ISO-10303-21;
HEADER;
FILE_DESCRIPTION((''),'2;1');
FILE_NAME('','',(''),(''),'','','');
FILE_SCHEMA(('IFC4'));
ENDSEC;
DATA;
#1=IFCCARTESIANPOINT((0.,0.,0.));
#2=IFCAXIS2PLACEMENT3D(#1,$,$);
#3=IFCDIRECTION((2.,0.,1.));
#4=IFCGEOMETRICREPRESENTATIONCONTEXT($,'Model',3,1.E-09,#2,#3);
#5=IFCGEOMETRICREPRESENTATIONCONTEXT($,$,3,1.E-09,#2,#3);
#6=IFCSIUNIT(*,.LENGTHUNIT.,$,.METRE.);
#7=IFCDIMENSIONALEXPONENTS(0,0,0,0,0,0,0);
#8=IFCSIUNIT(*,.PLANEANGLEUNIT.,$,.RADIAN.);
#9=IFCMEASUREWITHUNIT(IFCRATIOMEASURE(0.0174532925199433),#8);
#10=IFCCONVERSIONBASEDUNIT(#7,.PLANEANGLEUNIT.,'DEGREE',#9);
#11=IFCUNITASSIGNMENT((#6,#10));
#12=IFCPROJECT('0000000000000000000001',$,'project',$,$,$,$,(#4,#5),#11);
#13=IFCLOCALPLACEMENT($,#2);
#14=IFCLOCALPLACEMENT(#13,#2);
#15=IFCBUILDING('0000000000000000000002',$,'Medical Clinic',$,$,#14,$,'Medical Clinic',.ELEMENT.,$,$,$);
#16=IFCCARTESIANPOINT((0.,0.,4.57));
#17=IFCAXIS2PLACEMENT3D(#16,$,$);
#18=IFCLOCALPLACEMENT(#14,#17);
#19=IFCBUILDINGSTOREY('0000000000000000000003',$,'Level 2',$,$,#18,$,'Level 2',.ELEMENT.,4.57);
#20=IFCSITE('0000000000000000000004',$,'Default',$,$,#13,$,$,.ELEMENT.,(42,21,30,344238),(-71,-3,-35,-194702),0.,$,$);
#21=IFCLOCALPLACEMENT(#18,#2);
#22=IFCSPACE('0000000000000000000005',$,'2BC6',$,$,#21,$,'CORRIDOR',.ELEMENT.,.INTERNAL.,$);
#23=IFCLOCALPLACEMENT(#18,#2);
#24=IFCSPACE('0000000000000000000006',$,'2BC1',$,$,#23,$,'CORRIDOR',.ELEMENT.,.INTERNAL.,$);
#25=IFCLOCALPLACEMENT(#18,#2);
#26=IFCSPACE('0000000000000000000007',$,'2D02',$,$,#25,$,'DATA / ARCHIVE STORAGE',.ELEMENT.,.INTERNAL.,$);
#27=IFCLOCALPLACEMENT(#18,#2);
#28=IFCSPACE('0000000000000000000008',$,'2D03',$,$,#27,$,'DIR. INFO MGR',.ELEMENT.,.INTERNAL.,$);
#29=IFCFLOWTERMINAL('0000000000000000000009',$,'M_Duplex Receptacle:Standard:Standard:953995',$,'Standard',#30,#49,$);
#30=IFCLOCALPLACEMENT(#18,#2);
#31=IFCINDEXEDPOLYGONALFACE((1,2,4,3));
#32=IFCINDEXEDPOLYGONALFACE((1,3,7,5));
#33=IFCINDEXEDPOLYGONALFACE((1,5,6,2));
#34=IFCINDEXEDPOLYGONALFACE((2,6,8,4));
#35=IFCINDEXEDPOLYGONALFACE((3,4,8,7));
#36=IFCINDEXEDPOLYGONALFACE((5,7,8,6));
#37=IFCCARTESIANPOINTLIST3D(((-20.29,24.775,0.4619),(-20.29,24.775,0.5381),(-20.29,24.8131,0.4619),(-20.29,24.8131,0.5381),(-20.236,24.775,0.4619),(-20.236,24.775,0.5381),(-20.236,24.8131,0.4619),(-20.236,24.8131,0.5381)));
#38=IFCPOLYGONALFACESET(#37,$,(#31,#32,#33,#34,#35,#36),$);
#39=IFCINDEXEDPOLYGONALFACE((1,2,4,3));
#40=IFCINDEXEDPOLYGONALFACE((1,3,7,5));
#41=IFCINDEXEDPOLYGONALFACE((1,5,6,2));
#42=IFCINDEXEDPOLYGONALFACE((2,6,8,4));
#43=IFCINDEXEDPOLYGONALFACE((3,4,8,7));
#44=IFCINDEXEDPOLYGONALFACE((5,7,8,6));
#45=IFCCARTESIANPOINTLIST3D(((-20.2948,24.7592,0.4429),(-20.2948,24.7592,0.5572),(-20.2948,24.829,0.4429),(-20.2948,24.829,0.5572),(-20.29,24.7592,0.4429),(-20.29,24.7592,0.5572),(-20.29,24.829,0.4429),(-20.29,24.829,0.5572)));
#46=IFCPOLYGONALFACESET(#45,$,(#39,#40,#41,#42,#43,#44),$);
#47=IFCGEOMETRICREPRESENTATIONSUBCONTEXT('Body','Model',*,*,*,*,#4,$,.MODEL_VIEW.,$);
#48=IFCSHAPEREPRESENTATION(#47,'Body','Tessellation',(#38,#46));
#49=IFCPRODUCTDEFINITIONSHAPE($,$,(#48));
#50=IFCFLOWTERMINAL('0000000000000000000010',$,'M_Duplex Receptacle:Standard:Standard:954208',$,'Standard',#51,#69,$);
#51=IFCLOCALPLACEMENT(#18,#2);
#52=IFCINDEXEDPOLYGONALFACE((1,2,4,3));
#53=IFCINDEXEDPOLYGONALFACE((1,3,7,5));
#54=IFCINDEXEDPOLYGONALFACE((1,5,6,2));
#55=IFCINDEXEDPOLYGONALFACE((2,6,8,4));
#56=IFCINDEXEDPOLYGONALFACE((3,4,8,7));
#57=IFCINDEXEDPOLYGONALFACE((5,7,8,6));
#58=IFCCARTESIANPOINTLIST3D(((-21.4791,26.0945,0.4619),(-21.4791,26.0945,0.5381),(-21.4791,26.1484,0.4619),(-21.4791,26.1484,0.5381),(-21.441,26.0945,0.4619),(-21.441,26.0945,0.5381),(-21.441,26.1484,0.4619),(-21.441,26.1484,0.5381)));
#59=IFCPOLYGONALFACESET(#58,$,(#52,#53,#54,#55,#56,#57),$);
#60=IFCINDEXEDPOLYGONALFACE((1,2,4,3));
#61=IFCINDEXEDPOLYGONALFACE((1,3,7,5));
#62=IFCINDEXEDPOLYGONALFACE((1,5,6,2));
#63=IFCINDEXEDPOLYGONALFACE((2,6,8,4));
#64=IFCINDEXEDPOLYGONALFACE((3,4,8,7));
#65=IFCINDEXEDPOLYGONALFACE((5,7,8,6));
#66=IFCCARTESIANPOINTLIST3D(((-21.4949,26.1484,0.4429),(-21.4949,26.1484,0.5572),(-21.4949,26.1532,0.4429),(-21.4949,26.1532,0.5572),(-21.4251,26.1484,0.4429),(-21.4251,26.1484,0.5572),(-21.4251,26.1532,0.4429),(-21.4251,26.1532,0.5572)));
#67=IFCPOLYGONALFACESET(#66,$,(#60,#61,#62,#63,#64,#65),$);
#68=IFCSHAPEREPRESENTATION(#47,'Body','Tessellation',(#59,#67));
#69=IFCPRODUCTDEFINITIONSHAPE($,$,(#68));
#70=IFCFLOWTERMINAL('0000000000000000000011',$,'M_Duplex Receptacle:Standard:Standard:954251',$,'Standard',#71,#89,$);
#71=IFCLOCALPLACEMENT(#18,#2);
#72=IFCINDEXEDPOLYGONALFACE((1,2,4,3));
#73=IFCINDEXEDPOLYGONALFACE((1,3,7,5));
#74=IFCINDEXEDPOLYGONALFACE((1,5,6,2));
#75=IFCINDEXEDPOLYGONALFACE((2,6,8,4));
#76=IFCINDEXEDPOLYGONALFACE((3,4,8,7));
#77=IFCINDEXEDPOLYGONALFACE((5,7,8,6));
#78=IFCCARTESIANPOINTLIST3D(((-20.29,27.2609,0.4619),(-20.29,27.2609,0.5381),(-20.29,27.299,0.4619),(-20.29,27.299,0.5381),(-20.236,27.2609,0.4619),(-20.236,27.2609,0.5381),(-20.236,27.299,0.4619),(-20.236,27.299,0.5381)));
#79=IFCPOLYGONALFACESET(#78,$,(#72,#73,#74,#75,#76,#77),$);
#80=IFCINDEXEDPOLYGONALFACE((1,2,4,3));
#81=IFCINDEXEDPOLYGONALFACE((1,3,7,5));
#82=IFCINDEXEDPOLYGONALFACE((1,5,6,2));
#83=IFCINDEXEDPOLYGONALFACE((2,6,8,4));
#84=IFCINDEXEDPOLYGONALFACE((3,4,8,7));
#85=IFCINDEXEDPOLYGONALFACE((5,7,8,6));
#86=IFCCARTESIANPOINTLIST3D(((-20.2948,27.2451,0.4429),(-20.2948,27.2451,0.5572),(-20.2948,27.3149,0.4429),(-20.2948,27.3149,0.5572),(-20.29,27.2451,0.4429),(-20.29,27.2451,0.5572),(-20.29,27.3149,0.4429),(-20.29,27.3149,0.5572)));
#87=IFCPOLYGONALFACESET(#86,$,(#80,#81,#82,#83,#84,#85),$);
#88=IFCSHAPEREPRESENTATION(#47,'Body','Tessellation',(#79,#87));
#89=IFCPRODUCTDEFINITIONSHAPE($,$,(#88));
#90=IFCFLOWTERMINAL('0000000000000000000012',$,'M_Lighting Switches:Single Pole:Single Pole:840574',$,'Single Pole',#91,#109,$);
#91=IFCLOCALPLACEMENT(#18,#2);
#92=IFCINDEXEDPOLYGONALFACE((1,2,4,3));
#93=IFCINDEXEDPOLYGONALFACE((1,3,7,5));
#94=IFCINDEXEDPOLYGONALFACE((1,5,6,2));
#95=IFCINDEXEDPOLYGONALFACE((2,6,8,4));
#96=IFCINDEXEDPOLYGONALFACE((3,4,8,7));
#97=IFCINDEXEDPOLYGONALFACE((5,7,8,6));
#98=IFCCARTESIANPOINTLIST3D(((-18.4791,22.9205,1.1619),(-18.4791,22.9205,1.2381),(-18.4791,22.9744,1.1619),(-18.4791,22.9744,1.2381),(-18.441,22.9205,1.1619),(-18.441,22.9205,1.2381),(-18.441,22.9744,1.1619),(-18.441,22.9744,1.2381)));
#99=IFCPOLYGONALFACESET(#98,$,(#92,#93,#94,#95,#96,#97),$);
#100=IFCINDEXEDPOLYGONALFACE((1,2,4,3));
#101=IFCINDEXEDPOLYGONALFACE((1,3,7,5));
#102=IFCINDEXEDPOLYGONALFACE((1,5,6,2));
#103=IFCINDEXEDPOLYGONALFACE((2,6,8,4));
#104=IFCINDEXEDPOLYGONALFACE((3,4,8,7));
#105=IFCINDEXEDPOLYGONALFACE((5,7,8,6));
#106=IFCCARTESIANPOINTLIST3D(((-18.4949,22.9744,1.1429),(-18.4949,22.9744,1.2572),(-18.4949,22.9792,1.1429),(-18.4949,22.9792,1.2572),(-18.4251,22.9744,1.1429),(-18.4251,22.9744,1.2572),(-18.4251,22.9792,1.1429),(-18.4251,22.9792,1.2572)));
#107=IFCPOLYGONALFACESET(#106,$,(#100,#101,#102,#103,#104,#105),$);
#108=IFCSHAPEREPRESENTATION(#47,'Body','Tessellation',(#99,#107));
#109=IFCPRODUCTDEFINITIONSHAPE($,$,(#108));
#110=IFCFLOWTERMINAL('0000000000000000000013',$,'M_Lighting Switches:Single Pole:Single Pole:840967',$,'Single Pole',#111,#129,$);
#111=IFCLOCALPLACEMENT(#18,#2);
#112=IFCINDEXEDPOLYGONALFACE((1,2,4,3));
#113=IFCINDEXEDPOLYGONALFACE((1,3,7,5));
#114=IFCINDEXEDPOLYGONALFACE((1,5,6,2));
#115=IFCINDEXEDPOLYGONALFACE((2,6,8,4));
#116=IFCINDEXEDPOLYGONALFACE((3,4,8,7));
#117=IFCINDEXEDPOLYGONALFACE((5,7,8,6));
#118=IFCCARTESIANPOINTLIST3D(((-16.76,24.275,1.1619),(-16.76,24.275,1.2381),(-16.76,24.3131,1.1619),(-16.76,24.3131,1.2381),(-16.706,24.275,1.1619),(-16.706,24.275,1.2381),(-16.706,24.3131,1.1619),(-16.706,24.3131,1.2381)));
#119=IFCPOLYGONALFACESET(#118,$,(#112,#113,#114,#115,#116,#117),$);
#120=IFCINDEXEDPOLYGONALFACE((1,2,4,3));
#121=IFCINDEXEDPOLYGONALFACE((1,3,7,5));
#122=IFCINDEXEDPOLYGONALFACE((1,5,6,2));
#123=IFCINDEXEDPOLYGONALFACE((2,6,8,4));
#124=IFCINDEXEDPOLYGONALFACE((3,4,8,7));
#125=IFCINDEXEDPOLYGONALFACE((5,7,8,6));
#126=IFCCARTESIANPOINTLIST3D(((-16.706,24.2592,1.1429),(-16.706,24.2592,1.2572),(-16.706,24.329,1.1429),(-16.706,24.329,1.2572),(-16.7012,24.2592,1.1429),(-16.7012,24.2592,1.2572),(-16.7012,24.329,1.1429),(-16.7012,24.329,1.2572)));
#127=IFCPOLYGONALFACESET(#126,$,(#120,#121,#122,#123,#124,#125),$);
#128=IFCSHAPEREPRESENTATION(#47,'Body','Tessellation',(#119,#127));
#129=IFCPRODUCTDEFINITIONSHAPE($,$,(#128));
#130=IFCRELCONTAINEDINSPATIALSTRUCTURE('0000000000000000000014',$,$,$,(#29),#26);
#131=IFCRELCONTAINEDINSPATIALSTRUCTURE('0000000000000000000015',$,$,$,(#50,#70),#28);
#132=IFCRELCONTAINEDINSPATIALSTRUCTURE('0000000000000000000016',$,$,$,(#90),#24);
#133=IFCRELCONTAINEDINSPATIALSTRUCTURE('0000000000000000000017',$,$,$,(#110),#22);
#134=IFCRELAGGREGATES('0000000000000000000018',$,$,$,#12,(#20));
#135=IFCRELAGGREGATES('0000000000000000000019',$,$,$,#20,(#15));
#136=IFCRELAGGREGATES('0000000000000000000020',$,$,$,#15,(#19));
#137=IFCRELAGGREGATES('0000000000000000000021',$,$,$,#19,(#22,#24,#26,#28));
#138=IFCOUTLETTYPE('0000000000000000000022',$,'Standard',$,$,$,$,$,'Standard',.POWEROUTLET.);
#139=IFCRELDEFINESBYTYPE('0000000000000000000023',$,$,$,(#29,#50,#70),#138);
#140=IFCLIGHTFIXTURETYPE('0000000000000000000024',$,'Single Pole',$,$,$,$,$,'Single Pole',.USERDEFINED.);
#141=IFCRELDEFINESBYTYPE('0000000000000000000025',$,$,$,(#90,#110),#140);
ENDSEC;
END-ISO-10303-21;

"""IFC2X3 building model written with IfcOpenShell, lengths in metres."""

from ifc_helpers import new_model, entity, si_unit, converted_unit, direction, frame, frame_2d, origin, origin_2d_with_axis, place, context, subcontext, project, spatial, rectangle, extrude, source, transform, mapped, type_object, type_shapes, element, save


model = new_model("IFC2X3")

# Units and contexts
model_context = context("Model", 3, precision=1e-09, world=origin(), true_north=direction((2.0, 0.0, 1.0)))
context_of_model = context(None, 3, precision=1e-09, world=origin(), true_north=direction((2.0, 0.0, 1.0)))
body_context = subcontext(model_context, "Body", "Model", "MODEL_VIEW")
ifc_project = project(units=[si_unit("LENGTHUNIT", "METRE"), converted_unit("PLANEANGLEUNIT", "DEGREE", entity("IfcRatioMeasure", 0.0174532925199433), si_unit("PLANEANGLEUNIT", "RADIAN"), dimensions=[0, 0, 0, 0, 0, 0, 0])], contexts=[model_context, context_of_model])

# Site, building, storey
site_placement = place(None, origin())
site = spatial("IfcSite", under=ifc_project, at=site_placement, Name="Default", CompositionType="ELEMENT", RefLatitude=(42, 21, 30, 344238), RefLongitude=(-71, -3, -35, -194702), RefElevation=0.0)
building_placement = place(site_placement, origin())
building = spatial("IfcBuilding", under=site, at=building_placement, Name="Medical Clinic", LongName="Medical Clinic", CompositionType="ELEMENT")
storey_placement = place(building_placement, frame((0.0, 0.0, 4.57)))
storey = spatial("IfcBuildingStorey", under=building, at=storey_placement, Name="Level 2", LongName="Level 2", CompositionType="ELEMENT", Elevation=4.57)

# Shared definitions
outlet_type = type_object("IfcOutletType", Name="Standard", ElementType="Standard", PredefinedType="POWEROUTLET")
shared_shape_1 = source(origin(), body_context, "Body", "SweptSolid", [
    extrude(rectangle(XDim=0.0381, YDim=0.0762, at=origin_2d_with_axis()), frame((0.0, 0.0, -0.054), z_axis=(0.0, 0.0, 1.0), x_axis=(-1.0, 0.0, 0.0)), (0.0, 0.0, 1.0), 0.054),
    extrude(rectangle(XDim=0.0698, YDim=0.1143, at=frame_2d((0.0, 0.0), x_axis=(1.0, 0.0))), frame((0.0, 0.0, 0.0), z_axis=(0.0, 0.0, 1.0), x_axis=(-1.0, 0.0, 0.0)), (0.0, 0.0, 1.0), 0.0048),
])
type_shapes(outlet_type, [shared_shape_1])

# Shared definitions
space_1_placement = place(storey_placement, origin())
space_1 = spatial("IfcSpace", under=storey, at=space_1_placement, Name="2BC6", LongName="CORRIDOR", CompositionType="ELEMENT", InteriorOrExteriorSpace="INTERNAL")

# Shared definitions
space_2_placement = place(storey_placement, origin())
space_2 = spatial("IfcSpace", under=storey, at=space_2_placement, Name="2BC1", LongName="CORRIDOR", CompositionType="ELEMENT", InteriorOrExteriorSpace="INTERNAL")

# Shared definitions
space_3_placement = place(storey_placement, origin())
space_3 = spatial("IfcSpace", under=storey, at=space_3_placement, Name="2D02", LongName="DATA / ARCHIVE STORAGE", CompositionType="ELEMENT", InteriorOrExteriorSpace="INTERNAL")

# Flow terminal
flow_terminal_1_placement = place(space_3_placement, frame((-20.29, 24.7941, 0.5), z_axis=(-1.0, 0.0, 0.0), x_axis=(0.0, -1.0, 0.0)))
element("IfcFlowTerminal", 1, at=flow_terminal_1_placement, inside=space_3, type_object=outlet_type, Name="M_Duplex Receptacle:Standard:Standard:953995", ObjectType="Standard", context=body_context, shape_type="MappedRepresentation", body=[
    mapped(shared_shape_1, transform((0.0, 0.0, 0.0), scale=1.0)),
])

# Shared definitions
space_4_placement = place(storey_placement, origin())
space_4 = spatial("IfcSpace", under=storey, at=space_4_placement, Name="2D03", LongName="DIR. INFO MGR", CompositionType="ELEMENT", InteriorOrExteriorSpace="INTERNAL")

# Flow terminals
for number, where, z_axis, x_axis, name in (
    (2, (-21.46, 26.1484, 0.5), (0.0, 1.0, 0.0), (-1.0, 0.0, 0.0), "M_Duplex Receptacle:Standard:Standard:954208"),
    (3, (-20.29, 27.28, 0.5), (-1.0, 0.0, 0.0), (0.0, -1.0, 0.0), "M_Duplex Receptacle:Standard:Standard:954251"),
):
    element("IfcFlowTerminal", number, at=place(space_4_placement, frame(where, z_axis=z_axis, x_axis=x_axis)), inside=space_4, type_object=outlet_type, Name=name, ObjectType="Standard", context=body_context, shape_type="MappedRepresentation", body=[
        mapped(shared_shape_1, transform((0.0, 0.0, 0.0), scale=1.0)),
    ])
light_fixture_type_1 = type_object("IfcLightFixtureType", Name="Single Pole", ElementType="Single Pole", PredefinedType="USERDEFINED")
shared_shape_2 = source(origin(), body_context, "Body", "SweptSolid", [
    extrude(rectangle(XDim=0.0381, YDim=0.0762, at=origin_2d_with_axis()), frame((0.0, 0.0, -0.054), z_axis=(0.0, 0.0, 1.0), x_axis=(-1.0, 0.0, 0.0)), (0.0, 0.0, 1.0), 0.054),
    extrude(rectangle(XDim=0.0698, YDim=0.1143, at=frame_2d((0.0, 0.0), x_axis=(1.0, 0.0))), frame((0.0, 0.0, 0.0), z_axis=(0.0, 0.0, 1.0), x_axis=(-1.0, 0.0, 0.0)), (0.0, 0.0, 1.0), 0.0048),
])
type_shapes(light_fixture_type_1, [shared_shape_2])
flow_terminal_2_placement = place(space_2_placement, frame((-18.46, 22.9744, 1.2), z_axis=(0.0, 1.0, 0.0), x_axis=(-1.0, 0.0, 0.0)))
element("IfcFlowTerminal", 4, at=flow_terminal_2_placement, inside=space_2, type_object=light_fixture_type_1, Name="M_Lighting Switches:Single Pole:Single Pole:840574", ObjectType="Single Pole", context=body_context, shape_type="MappedRepresentation", body=[
    mapped(shared_shape_2, transform((0.0, 0.0, 0.0), scale=1.0)),
])
flow_terminal_3_placement = place(space_1_placement, frame((-16.706, 24.2941, 1.2), z_axis=(1.0, 0.0, 0.0), x_axis=(0.0, 1.0, 0.0)))
element("IfcFlowTerminal", 5, at=flow_terminal_3_placement, inside=space_1, type_object=light_fixture_type_1, Name="M_Lighting Switches:Single Pole:Single Pole:840967", ObjectType="Single Pole", context=body_context, shape_type="MappedRepresentation", body=[
    mapped(shared_shape_2, transform((0.0, 0.0, 0.0), scale=1.0)),
])

save(model, "model.ifc")
